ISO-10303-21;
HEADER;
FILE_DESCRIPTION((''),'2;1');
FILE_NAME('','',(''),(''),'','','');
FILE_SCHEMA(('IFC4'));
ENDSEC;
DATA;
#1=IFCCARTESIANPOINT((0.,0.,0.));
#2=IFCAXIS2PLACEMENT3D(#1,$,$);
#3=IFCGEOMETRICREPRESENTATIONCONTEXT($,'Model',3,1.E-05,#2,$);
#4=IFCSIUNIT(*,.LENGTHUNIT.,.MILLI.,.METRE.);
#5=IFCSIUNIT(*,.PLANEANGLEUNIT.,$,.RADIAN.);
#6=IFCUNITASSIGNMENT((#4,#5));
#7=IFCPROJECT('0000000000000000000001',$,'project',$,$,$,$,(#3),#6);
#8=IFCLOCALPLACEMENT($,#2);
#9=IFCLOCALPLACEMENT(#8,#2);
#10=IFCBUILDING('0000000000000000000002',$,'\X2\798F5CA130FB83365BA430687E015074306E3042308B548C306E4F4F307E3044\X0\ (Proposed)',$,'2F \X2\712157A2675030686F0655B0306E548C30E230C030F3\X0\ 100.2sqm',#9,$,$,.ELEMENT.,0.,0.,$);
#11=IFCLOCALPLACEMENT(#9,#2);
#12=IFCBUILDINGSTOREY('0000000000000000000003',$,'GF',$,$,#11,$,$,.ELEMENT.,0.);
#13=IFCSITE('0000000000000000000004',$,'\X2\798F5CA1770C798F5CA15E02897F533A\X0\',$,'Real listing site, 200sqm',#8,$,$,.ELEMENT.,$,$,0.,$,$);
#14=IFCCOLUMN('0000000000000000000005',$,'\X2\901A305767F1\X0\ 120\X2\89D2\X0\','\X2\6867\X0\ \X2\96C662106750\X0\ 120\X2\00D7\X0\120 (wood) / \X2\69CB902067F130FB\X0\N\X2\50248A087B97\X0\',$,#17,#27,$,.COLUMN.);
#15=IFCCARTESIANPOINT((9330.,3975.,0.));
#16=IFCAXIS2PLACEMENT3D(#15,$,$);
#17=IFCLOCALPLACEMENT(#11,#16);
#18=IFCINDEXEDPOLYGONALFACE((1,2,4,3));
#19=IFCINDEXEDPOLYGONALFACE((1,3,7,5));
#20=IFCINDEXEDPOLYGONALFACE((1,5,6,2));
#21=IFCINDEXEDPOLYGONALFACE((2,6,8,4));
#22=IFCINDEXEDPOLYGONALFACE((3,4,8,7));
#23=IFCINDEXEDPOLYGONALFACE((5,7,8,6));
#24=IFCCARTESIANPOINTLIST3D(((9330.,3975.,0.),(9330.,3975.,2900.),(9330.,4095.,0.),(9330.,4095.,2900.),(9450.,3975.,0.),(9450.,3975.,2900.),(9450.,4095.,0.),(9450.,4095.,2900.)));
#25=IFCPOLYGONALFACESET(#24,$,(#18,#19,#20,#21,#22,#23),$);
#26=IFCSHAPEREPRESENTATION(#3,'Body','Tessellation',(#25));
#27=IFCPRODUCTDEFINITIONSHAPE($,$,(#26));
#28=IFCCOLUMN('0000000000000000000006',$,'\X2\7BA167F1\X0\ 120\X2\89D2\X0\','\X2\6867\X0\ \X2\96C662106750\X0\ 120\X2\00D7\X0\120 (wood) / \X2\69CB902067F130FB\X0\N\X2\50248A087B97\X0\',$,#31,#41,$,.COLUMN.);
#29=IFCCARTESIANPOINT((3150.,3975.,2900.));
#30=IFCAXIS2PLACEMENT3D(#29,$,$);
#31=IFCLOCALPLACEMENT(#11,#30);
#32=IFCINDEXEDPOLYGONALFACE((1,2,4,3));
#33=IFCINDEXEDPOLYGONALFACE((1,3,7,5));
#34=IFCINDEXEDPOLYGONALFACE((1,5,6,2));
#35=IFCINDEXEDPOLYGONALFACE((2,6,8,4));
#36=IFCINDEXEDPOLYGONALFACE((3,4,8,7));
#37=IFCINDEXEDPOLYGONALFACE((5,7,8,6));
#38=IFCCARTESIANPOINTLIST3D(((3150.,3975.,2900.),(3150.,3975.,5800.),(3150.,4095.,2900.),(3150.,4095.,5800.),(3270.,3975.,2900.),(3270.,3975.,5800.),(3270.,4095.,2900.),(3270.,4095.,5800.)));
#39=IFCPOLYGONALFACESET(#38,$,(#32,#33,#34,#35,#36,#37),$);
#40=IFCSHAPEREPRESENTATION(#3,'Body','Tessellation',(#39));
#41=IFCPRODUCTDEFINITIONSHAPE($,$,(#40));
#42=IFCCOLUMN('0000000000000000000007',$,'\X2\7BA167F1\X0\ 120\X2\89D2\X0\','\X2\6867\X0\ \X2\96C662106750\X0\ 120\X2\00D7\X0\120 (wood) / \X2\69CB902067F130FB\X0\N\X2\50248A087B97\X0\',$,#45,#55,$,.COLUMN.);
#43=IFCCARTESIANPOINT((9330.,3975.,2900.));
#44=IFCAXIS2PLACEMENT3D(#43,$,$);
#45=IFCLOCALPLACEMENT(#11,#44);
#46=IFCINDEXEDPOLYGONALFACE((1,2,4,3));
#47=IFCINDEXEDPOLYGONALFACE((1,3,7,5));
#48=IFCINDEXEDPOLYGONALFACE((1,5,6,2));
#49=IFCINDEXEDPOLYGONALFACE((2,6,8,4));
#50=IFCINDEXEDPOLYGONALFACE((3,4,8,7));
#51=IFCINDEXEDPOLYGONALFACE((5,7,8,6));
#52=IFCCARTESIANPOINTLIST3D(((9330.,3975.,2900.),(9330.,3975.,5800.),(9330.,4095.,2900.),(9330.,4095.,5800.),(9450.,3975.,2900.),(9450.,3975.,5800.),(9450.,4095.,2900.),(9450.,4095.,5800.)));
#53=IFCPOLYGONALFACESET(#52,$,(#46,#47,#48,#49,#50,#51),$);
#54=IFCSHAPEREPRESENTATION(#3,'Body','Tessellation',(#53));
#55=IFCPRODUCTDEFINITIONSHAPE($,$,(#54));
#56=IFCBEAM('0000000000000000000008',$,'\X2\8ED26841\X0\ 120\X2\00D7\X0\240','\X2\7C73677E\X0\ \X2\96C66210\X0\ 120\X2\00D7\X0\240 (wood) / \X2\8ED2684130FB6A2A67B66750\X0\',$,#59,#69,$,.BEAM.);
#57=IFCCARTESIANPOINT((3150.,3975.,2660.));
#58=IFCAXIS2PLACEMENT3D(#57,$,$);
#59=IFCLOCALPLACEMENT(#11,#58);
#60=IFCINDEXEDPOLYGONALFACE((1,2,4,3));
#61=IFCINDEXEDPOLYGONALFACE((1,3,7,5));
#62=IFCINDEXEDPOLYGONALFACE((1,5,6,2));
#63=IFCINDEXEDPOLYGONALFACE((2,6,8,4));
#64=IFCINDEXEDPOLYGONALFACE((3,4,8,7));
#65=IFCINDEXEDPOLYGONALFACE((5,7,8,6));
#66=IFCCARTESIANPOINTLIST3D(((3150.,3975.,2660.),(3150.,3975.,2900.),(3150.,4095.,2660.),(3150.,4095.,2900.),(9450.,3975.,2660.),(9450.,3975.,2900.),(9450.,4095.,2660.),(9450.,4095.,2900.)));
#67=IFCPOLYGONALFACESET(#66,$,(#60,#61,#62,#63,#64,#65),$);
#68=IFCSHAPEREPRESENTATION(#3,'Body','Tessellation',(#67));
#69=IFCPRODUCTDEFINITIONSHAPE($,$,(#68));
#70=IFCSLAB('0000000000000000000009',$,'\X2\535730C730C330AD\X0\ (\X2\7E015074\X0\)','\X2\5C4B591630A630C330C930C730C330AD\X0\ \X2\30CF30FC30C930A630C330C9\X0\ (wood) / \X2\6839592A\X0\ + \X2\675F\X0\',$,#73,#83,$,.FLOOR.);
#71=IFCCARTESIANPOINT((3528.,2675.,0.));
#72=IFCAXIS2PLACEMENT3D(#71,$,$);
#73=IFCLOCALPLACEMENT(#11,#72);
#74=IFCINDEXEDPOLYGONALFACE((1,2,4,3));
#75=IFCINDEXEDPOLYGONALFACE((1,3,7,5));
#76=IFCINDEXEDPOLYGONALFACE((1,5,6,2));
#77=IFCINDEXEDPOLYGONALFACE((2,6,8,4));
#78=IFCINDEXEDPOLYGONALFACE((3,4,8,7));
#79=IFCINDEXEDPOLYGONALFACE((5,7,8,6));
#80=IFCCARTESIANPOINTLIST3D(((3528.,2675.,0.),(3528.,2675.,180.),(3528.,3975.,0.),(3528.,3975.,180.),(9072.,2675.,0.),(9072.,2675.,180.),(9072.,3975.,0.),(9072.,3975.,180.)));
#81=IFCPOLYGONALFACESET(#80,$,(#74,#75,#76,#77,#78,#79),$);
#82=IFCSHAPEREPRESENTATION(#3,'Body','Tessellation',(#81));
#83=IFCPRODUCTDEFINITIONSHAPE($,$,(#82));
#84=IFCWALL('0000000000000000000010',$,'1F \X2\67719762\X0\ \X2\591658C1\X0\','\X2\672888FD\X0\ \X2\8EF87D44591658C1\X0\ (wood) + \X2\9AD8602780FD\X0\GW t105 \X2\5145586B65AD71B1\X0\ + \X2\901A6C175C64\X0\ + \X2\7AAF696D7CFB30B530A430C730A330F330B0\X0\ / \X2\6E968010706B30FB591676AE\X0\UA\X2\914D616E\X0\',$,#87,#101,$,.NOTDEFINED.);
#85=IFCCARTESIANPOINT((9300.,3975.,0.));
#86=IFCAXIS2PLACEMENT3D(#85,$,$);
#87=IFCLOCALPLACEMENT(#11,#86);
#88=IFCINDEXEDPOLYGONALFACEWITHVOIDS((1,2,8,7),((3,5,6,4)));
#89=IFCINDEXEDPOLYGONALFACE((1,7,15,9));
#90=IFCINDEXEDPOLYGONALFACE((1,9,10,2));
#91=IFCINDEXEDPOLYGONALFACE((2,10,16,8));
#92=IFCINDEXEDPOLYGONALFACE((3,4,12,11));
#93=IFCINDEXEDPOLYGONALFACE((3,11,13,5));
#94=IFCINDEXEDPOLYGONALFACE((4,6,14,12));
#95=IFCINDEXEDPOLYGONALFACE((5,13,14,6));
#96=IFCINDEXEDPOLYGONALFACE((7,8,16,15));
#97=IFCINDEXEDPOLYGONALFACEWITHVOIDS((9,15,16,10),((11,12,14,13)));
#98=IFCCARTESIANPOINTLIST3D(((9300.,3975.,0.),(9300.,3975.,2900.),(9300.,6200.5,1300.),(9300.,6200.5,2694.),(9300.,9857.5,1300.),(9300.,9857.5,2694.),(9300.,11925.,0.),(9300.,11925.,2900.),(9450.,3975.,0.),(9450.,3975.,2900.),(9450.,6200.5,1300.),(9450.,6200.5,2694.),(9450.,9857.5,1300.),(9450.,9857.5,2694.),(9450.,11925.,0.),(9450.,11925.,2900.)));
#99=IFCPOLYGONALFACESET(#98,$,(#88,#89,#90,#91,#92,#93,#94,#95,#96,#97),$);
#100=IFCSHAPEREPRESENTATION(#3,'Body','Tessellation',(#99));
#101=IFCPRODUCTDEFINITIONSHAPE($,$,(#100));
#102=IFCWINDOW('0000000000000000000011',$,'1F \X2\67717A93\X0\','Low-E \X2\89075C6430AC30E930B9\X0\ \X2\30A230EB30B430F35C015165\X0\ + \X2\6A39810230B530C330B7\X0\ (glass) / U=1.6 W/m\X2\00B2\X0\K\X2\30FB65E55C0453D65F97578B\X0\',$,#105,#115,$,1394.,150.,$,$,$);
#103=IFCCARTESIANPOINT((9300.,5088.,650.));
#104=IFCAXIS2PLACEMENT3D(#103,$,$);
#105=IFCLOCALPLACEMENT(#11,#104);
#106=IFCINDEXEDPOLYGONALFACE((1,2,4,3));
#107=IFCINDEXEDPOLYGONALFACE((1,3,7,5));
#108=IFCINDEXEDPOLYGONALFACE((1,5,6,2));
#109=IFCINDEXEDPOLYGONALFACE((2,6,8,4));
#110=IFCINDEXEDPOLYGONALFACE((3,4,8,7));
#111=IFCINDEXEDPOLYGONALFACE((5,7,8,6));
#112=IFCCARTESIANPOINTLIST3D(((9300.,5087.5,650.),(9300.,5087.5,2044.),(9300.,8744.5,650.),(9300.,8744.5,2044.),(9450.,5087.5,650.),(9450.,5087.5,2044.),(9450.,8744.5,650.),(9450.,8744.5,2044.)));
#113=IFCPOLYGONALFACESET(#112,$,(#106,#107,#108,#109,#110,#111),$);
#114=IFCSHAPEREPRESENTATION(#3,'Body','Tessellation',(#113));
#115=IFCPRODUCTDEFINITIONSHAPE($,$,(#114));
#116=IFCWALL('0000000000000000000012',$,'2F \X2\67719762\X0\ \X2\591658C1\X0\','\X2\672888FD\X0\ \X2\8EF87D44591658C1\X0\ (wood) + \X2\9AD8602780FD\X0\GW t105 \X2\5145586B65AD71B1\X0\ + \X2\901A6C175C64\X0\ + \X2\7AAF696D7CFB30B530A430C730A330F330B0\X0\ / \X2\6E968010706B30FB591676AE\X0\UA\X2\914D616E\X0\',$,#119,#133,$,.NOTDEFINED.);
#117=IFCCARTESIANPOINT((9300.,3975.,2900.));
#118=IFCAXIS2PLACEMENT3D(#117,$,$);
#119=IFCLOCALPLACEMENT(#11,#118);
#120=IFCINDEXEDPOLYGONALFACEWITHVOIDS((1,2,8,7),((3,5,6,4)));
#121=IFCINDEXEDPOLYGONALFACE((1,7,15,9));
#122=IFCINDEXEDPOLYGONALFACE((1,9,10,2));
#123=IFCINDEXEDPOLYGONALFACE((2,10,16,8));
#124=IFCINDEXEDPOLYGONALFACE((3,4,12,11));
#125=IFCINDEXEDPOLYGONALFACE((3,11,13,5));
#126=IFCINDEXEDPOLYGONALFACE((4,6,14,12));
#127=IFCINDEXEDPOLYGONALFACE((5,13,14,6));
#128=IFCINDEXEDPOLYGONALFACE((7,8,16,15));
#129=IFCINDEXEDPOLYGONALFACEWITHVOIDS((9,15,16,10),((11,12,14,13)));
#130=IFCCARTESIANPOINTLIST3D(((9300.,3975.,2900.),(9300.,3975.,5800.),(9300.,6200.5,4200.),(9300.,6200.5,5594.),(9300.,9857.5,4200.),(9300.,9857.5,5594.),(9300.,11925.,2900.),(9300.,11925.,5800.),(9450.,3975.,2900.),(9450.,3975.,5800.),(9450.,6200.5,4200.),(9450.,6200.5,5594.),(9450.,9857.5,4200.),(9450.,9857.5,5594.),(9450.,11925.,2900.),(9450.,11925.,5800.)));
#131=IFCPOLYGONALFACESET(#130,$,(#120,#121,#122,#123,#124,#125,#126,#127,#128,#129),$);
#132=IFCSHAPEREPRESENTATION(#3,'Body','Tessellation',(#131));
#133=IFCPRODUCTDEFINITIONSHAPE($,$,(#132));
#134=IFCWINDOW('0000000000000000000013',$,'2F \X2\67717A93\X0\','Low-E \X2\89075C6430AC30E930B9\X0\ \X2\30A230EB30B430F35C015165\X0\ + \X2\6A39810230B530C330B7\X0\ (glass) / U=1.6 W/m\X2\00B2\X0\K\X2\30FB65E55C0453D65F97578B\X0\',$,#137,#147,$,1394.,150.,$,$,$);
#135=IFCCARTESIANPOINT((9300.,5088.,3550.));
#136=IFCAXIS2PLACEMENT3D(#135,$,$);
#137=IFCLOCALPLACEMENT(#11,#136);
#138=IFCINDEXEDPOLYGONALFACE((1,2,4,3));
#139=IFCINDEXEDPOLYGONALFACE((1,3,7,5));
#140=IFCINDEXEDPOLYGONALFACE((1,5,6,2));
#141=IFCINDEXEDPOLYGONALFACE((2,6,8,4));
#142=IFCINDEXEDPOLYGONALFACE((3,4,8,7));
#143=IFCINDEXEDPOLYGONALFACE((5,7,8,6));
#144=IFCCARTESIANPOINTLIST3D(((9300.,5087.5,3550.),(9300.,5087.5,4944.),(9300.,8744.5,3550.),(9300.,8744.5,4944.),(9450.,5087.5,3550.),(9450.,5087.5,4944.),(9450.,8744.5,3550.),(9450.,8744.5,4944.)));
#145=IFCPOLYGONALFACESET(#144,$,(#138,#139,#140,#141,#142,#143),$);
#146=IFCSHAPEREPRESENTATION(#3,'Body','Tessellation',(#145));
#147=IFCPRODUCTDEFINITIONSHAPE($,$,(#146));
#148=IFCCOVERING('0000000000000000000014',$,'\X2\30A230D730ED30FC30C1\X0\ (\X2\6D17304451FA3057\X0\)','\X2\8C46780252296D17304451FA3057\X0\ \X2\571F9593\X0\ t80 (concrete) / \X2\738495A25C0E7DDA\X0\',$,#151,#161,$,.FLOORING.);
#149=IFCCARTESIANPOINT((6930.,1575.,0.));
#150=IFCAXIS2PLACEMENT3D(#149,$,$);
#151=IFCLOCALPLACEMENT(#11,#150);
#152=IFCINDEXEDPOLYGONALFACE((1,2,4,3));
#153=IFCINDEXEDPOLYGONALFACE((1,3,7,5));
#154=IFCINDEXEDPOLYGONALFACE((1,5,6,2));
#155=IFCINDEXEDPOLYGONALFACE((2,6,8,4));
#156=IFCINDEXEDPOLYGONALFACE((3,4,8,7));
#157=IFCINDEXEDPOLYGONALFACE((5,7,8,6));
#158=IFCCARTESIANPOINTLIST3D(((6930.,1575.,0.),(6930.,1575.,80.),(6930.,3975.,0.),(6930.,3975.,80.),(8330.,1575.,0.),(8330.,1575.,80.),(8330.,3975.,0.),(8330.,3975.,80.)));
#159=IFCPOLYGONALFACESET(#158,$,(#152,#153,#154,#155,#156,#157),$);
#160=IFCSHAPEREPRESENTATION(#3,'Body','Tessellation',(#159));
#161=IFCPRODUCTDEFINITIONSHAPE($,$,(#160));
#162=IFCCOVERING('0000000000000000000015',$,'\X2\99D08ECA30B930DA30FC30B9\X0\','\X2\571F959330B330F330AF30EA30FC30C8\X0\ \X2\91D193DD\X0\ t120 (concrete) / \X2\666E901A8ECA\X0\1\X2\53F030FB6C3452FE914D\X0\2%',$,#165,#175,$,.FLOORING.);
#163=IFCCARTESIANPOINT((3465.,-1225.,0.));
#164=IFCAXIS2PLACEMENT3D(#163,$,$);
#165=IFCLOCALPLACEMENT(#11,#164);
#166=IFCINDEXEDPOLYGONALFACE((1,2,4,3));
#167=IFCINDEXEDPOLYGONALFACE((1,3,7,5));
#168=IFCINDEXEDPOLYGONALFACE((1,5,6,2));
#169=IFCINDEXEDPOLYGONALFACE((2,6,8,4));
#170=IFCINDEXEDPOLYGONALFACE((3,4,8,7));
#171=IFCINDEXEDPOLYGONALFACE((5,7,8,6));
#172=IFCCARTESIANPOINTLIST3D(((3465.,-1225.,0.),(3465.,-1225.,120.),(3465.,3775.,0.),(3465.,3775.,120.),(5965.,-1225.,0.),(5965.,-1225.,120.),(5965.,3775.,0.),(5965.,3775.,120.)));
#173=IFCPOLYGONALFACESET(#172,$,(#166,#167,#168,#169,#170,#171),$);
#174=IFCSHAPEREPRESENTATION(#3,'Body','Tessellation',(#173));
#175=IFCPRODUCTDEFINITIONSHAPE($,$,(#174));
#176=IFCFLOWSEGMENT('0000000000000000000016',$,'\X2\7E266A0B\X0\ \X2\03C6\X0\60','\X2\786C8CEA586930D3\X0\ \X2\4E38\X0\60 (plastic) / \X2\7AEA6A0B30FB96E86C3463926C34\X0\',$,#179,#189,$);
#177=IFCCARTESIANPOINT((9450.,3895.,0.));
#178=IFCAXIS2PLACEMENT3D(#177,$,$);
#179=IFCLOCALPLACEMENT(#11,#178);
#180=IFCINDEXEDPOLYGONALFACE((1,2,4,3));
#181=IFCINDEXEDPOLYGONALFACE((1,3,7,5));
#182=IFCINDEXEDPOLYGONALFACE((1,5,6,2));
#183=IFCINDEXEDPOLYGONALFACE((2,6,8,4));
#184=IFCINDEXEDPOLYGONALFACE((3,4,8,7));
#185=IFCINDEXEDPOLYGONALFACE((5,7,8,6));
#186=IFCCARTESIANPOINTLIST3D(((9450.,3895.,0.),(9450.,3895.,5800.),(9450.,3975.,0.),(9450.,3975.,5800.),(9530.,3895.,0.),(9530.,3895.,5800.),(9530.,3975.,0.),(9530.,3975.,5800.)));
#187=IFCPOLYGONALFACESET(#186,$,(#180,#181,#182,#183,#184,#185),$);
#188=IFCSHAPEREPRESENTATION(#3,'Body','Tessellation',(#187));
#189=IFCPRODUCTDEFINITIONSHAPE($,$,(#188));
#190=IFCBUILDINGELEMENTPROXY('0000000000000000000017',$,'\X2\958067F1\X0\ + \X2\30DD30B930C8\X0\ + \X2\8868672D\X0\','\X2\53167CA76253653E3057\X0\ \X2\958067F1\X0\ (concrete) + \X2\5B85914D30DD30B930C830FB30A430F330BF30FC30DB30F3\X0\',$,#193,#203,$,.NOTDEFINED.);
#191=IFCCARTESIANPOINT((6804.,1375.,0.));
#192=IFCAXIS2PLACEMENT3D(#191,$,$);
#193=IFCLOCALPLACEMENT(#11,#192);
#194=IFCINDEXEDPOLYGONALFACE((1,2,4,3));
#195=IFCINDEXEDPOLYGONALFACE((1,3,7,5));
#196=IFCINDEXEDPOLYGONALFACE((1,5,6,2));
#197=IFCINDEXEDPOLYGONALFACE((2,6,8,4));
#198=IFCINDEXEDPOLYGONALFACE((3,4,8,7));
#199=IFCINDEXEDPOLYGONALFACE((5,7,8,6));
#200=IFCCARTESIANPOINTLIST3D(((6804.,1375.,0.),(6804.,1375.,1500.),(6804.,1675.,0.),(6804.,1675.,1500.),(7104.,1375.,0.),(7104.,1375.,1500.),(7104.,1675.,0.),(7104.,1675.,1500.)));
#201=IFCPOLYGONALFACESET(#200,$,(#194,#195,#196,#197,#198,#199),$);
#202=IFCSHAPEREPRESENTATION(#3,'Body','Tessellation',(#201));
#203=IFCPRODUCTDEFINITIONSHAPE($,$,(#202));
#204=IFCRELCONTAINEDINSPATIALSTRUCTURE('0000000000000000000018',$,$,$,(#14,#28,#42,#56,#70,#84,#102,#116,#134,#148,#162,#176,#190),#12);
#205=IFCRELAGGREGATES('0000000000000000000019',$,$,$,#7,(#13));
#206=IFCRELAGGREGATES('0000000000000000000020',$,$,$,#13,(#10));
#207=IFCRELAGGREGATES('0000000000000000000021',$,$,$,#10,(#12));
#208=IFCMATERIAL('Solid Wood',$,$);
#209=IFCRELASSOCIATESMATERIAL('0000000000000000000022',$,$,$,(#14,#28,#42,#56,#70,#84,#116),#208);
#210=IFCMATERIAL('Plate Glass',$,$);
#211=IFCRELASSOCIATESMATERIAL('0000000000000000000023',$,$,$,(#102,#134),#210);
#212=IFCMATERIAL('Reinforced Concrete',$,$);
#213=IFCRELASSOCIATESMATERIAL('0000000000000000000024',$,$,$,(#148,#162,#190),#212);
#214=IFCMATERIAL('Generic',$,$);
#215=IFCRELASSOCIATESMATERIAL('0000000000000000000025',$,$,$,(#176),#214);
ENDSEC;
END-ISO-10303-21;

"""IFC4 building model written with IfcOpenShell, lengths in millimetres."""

from ifc_helpers import new_model, si_unit, frame, frame_2d, origin, place, context, project, spatial, rectangle, extrude, material, element, fill, save


model = new_model("IFC4")

# Units and contexts
model_context = context("Model", 3, precision=1e-05, world=origin())
ifc_project = project(units=[si_unit("LENGTHUNIT", "METRE", prefix="MILLI"), si_unit("PLANEANGLEUNIT", "RADIAN")], contexts=[model_context])

# Site, building, storey
site_placement = place(None, origin())
site = spatial("IfcSite", under=ifc_project, at=site_placement, Name="福岡県福岡市西区", ObjectType="Real listing site, 200sqm", CompositionType="ELEMENT", RefElevation=0.0)
building_placement = place(site_placement, origin())
building = spatial("IfcBuilding", under=site, at=building_placement, Name="福岡・茶室と縁側のある和の住まい (Proposed)", ObjectType="2F 無垢材と漆喰の和モダン 100.2sqm", CompositionType="ELEMENT", ElevationOfRefHeight=0.0, ElevationOfTerrain=0.0)
storey_placement = place(building_placement, origin())
storey = spatial("IfcBuildingStorey", under=building, at=storey_placement, Name="GF", CompositionType="ELEMENT", Elevation=0.0)

# Columns
ifc_material_1 = material(Name="Solid Wood")
column_1_placement = place(storey_placement, frame((9330.0, 3975.0, 0.0)))
element("IfcColumn", 1, at=column_1_placement, inside=storey, material=ifc_material_1, Name="通し柱 120角", Description="桧 集成材 120×120 (wood) / 構造柱・N値計算", PredefinedType="COLUMN", context=model_context, shape_type="SweptSolid", body=[
    extrude(rectangle(XDim=120.0, YDim=120.0, at=frame_2d((60.0, 60.0))), frame((9330.0, 3975.0, 0.0)), (0.0, 0.0, 1.0), 2900.0),
])
column_2_placement = place(storey_placement, frame((3150.0, 3975.0, 2900.0)))
element("IfcColumn", 2, at=column_2_placement, inside=storey, material=ifc_material_1, Name="管柱 120角", Description="桧 集成材 120×120 (wood) / 構造柱・N値計算", PredefinedType="COLUMN", context=model_context, shape_type="SweptSolid", body=[
    extrude(rectangle(XDim=120.0, YDim=120.0, at=frame_2d((60.0, 60.0))), frame((3150.0, 3975.0, 2900.0)), (0.0, 0.0, 1.0), 2900.0),
])
column_3_placement = place(storey_placement, frame((9330.0, 3975.0, 2900.0)))
element("IfcColumn", 3, at=column_3_placement, inside=storey, material=ifc_material_1, Name="管柱 120角", Description="桧 集成材 120×120 (wood) / 構造柱・N値計算", PredefinedType="COLUMN", context=model_context, shape_type="SweptSolid", body=[
    extrude(rectangle(XDim=120.0, YDim=120.0, at=frame_2d((60.0, 60.0))), frame((9330.0, 3975.0, 2900.0)), (0.0, 0.0, 1.0), 2900.0),
])

# Beam
beam_1_placement = place(storey_placement, frame((3150.0, 3975.0, 2660.0)))
element("IfcBeam", 4, at=beam_1_placement, inside=storey, material=ifc_material_1, Name="軒桁 120×240", Description="米松 集成 120×240 (wood) / 軒桁・横架材", PredefinedType="BEAM", context=model_context, shape_type="SweptSolid", body=[
    extrude(rectangle(XDim=6300.0, YDim=120.0, at=frame_2d((3150.0, 60.0))), frame((3150.0, 3975.0, 2660.0)), (0.0, 0.0, 1.0), 240.0),
])

# Slab
slab_placement = place(storey_placement, frame((3528.0, 2675.0, 0.0)))
element("IfcSlab", 5, at=slab_placement, inside=storey, material=ifc_material_1, Name="南デッキ (縁側)", Description="屋外ウッドデッキ ハードウッド (wood) / 根太 + 束", PredefinedType="FLOOR", context=model_context, shape_type="SweptSolid", body=[
    extrude(rectangle(XDim=5544.0, YDim=1300.0, at=frame_2d((2772.0, 650.0))), frame((3528.0, 2675.0, 0.0)), (0.0, 0.0, 1.0), 180.0),
])

# Walls, openings, windows
wall_1_placement = place(storey_placement, frame((9300.0, 3975.0, 0.0)))
wall_1 = element("IfcWall", 6, at=wall_1_placement, inside=storey, material=ifc_material_1, Name="1F 東面 外壁", Description="木製 軸組外壁 (wood) + 高性能GW t105 充填断熱 + 通気層 + 窯業系サイディング / 準耐火・外皮UA配慮", PredefinedType="NOTDEFINED", context=model_context, shape_type="SweptSolid", body=[
    extrude(rectangle(XDim=150.0, YDim=7950.0, at=frame_2d((75.0, 3975.0))), frame((9300.0, 3975.0, 0.0)), (0.0, 0.0, 1.0), 2900.0),
])
opening_1_placement = place(storey_placement, frame((9300.0, 5088.0, 650.0)))
opening_1 = element("IfcOpeningElement", 7, at=opening_1_placement, cuts=wall_1, PredefinedType="NOTDEFINED", context=model_context, shape_type="SweptSolid", body=[
    extrude(rectangle(XDim=150.0, YDim=3657.0, at=frame_2d((75.0, 1828.0))), frame((9300.0, 5088.0, 650.0)), (0.0, 0.0, 1.0), 1394.0),
])
ifc_material_2 = material(Name="Plate Glass")
window_1_placement = place(storey_placement, frame((9300.0, 5088.0, 650.0)))
window_1 = element("IfcWindow", 8, at=window_1_placement, inside=storey, material=ifc_material_2, Name="1F 東窓", Description="Low-E 複層ガラス アルゴン封入 + 樹脂サッシ (glass) / U=1.6 W/m²K・日射取得型", OverallHeight=1394.0, OverallWidth=150.0, context=model_context, shape_type="SweptSolid", body=[
    extrude(rectangle(XDim=150.0, YDim=3657.0, at=frame_2d((75.0, 1828.0))), frame((9300.0, 5088.0, 650.0)), (0.0, 0.0, 1.0), 1394.0),
])
fill(opening_1, window_1)
wall_2_placement = place(storey_placement, frame((9300.0, 3975.0, 2900.0)))
wall_2 = element("IfcWall", 9, at=wall_2_placement, inside=storey, material=ifc_material_1, Name="2F 東面 外壁", Description="木製 軸組外壁 (wood) + 高性能GW t105 充填断熱 + 通気層 + 窯業系サイディング / 準耐火・外皮UA配慮", PredefinedType="NOTDEFINED", context=model_context, shape_type="SweptSolid", body=[
    extrude(rectangle(XDim=150.0, YDim=7950.0, at=frame_2d((75.0, 3975.0))), frame((9300.0, 3975.0, 2900.0)), (0.0, 0.0, 1.0), 2900.0),
])
opening_2_placement = place(storey_placement, frame((9300.0, 5088.0, 3550.0)))
opening_2 = element("IfcOpeningElement", 10, at=opening_2_placement, cuts=wall_2, PredefinedType="NOTDEFINED", context=model_context, shape_type="SweptSolid", body=[
    extrude(rectangle(XDim=150.0, YDim=3657.0, at=frame_2d((75.0, 1828.0))), frame((9300.0, 5088.0, 3550.0)), (0.0, 0.0, 1.0), 1394.0),
])
window_2_placement = place(storey_placement, frame((9300.0, 5088.0, 3550.0)))
window_2 = element("IfcWindow", 11, at=window_2_placement, inside=storey, material=ifc_material_2, Name="2F 東窓", Description="Low-E 複層ガラス アルゴン封入 + 樹脂サッシ (glass) / U=1.6 W/m²K・日射取得型", OverallHeight=1394.0, OverallWidth=150.0, context=model_context, shape_type="SweptSolid", body=[
    extrude(rectangle(XDim=150.0, YDim=3657.0, at=frame_2d((75.0, 1828.0))), frame((9300.0, 5088.0, 3550.0)), (0.0, 0.0, 1.0), 1394.0),
])
fill(opening_2, window_2)

# Coverings
ifc_material_3 = material(Name="Reinforced Concrete")
covering_1_placement = place(storey_placement, frame((6930.0, 1575.0, 0.0)))
element("IfcCovering", 12, at=covering_1_placement, inside=storey, material=ifc_material_3, Name="アプローチ (洗い出し)", Description="豆砂利洗い出し 土間 t80 (concrete) / 玄関導線", PredefinedType="FLOORING", context=model_context, shape_type="SweptSolid", body=[
    extrude(rectangle(XDim=1400.0, YDim=2400.0, at=frame_2d((700.0, 1200.0))), frame((6930.0, 1575.0, 0.0)), (0.0, 0.0, 1.0), 80.0),
])
covering_2_placement = place(storey_placement, frame((3465.0, -1225.0, 0.0)))
element("IfcCovering", 13, at=covering_2_placement, inside=storey, material=ifc_material_3, Name="駐車スペース", Description="土間コンクリート 金鏝 t120 (concrete) / 普通車1台・水勾配2%", PredefinedType="FLOORING", context=model_context, shape_type="SweptSolid", body=[
    extrude(rectangle(XDim=2500.0, YDim=5000.0, at=frame_2d((1250.0, 2500.0))), frame((3465.0, -1225.0, 0.0)), (0.0, 0.0, 1.0), 120.0),
])

# Flow segment
ifc_material_4 = material(Name="Generic")
flow_segment_placement = place(storey_placement, frame((9450.0, 3895.0, 0.0)))
element("IfcFlowSegment", 14, at=flow_segment_placement, inside=storey, material=ifc_material_4, Name="縦樋 φ60", Description="硬質塩ビ 丸60 (plastic) / 竪樋・雨水排水", context=model_context, shape_type="SweptSolid", body=[
    extrude(rectangle(XDim=80.0, YDim=80.0, at=frame_2d((40.0, 40.0))), frame((9450.0, 3895.0, 0.0)), (0.0, 0.0, 1.0), 5800.0),
])

# Building element proxy
proxy_placement = place(storey_placement, frame((6804.0, 1375.0, 0.0)))
element("IfcBuildingElementProxy", 15, at=proxy_placement, inside=storey, material=ifc_material_3, Name="門柱 + ポスト + 表札", Description="化粧打放し 門柱 (concrete) + 宅配ポスト・インターホン", PredefinedType="NOTDEFINED", context=model_context, shape_type="SweptSolid", body=[
    extrude(rectangle(XDim=300.0, YDim=300.0, at=frame_2d((150.0, 150.0))), frame((6804.0, 1375.0, 0.0)), (0.0, 0.0, 1.0), 1500.0),
])

save(model, "model.ifc")
